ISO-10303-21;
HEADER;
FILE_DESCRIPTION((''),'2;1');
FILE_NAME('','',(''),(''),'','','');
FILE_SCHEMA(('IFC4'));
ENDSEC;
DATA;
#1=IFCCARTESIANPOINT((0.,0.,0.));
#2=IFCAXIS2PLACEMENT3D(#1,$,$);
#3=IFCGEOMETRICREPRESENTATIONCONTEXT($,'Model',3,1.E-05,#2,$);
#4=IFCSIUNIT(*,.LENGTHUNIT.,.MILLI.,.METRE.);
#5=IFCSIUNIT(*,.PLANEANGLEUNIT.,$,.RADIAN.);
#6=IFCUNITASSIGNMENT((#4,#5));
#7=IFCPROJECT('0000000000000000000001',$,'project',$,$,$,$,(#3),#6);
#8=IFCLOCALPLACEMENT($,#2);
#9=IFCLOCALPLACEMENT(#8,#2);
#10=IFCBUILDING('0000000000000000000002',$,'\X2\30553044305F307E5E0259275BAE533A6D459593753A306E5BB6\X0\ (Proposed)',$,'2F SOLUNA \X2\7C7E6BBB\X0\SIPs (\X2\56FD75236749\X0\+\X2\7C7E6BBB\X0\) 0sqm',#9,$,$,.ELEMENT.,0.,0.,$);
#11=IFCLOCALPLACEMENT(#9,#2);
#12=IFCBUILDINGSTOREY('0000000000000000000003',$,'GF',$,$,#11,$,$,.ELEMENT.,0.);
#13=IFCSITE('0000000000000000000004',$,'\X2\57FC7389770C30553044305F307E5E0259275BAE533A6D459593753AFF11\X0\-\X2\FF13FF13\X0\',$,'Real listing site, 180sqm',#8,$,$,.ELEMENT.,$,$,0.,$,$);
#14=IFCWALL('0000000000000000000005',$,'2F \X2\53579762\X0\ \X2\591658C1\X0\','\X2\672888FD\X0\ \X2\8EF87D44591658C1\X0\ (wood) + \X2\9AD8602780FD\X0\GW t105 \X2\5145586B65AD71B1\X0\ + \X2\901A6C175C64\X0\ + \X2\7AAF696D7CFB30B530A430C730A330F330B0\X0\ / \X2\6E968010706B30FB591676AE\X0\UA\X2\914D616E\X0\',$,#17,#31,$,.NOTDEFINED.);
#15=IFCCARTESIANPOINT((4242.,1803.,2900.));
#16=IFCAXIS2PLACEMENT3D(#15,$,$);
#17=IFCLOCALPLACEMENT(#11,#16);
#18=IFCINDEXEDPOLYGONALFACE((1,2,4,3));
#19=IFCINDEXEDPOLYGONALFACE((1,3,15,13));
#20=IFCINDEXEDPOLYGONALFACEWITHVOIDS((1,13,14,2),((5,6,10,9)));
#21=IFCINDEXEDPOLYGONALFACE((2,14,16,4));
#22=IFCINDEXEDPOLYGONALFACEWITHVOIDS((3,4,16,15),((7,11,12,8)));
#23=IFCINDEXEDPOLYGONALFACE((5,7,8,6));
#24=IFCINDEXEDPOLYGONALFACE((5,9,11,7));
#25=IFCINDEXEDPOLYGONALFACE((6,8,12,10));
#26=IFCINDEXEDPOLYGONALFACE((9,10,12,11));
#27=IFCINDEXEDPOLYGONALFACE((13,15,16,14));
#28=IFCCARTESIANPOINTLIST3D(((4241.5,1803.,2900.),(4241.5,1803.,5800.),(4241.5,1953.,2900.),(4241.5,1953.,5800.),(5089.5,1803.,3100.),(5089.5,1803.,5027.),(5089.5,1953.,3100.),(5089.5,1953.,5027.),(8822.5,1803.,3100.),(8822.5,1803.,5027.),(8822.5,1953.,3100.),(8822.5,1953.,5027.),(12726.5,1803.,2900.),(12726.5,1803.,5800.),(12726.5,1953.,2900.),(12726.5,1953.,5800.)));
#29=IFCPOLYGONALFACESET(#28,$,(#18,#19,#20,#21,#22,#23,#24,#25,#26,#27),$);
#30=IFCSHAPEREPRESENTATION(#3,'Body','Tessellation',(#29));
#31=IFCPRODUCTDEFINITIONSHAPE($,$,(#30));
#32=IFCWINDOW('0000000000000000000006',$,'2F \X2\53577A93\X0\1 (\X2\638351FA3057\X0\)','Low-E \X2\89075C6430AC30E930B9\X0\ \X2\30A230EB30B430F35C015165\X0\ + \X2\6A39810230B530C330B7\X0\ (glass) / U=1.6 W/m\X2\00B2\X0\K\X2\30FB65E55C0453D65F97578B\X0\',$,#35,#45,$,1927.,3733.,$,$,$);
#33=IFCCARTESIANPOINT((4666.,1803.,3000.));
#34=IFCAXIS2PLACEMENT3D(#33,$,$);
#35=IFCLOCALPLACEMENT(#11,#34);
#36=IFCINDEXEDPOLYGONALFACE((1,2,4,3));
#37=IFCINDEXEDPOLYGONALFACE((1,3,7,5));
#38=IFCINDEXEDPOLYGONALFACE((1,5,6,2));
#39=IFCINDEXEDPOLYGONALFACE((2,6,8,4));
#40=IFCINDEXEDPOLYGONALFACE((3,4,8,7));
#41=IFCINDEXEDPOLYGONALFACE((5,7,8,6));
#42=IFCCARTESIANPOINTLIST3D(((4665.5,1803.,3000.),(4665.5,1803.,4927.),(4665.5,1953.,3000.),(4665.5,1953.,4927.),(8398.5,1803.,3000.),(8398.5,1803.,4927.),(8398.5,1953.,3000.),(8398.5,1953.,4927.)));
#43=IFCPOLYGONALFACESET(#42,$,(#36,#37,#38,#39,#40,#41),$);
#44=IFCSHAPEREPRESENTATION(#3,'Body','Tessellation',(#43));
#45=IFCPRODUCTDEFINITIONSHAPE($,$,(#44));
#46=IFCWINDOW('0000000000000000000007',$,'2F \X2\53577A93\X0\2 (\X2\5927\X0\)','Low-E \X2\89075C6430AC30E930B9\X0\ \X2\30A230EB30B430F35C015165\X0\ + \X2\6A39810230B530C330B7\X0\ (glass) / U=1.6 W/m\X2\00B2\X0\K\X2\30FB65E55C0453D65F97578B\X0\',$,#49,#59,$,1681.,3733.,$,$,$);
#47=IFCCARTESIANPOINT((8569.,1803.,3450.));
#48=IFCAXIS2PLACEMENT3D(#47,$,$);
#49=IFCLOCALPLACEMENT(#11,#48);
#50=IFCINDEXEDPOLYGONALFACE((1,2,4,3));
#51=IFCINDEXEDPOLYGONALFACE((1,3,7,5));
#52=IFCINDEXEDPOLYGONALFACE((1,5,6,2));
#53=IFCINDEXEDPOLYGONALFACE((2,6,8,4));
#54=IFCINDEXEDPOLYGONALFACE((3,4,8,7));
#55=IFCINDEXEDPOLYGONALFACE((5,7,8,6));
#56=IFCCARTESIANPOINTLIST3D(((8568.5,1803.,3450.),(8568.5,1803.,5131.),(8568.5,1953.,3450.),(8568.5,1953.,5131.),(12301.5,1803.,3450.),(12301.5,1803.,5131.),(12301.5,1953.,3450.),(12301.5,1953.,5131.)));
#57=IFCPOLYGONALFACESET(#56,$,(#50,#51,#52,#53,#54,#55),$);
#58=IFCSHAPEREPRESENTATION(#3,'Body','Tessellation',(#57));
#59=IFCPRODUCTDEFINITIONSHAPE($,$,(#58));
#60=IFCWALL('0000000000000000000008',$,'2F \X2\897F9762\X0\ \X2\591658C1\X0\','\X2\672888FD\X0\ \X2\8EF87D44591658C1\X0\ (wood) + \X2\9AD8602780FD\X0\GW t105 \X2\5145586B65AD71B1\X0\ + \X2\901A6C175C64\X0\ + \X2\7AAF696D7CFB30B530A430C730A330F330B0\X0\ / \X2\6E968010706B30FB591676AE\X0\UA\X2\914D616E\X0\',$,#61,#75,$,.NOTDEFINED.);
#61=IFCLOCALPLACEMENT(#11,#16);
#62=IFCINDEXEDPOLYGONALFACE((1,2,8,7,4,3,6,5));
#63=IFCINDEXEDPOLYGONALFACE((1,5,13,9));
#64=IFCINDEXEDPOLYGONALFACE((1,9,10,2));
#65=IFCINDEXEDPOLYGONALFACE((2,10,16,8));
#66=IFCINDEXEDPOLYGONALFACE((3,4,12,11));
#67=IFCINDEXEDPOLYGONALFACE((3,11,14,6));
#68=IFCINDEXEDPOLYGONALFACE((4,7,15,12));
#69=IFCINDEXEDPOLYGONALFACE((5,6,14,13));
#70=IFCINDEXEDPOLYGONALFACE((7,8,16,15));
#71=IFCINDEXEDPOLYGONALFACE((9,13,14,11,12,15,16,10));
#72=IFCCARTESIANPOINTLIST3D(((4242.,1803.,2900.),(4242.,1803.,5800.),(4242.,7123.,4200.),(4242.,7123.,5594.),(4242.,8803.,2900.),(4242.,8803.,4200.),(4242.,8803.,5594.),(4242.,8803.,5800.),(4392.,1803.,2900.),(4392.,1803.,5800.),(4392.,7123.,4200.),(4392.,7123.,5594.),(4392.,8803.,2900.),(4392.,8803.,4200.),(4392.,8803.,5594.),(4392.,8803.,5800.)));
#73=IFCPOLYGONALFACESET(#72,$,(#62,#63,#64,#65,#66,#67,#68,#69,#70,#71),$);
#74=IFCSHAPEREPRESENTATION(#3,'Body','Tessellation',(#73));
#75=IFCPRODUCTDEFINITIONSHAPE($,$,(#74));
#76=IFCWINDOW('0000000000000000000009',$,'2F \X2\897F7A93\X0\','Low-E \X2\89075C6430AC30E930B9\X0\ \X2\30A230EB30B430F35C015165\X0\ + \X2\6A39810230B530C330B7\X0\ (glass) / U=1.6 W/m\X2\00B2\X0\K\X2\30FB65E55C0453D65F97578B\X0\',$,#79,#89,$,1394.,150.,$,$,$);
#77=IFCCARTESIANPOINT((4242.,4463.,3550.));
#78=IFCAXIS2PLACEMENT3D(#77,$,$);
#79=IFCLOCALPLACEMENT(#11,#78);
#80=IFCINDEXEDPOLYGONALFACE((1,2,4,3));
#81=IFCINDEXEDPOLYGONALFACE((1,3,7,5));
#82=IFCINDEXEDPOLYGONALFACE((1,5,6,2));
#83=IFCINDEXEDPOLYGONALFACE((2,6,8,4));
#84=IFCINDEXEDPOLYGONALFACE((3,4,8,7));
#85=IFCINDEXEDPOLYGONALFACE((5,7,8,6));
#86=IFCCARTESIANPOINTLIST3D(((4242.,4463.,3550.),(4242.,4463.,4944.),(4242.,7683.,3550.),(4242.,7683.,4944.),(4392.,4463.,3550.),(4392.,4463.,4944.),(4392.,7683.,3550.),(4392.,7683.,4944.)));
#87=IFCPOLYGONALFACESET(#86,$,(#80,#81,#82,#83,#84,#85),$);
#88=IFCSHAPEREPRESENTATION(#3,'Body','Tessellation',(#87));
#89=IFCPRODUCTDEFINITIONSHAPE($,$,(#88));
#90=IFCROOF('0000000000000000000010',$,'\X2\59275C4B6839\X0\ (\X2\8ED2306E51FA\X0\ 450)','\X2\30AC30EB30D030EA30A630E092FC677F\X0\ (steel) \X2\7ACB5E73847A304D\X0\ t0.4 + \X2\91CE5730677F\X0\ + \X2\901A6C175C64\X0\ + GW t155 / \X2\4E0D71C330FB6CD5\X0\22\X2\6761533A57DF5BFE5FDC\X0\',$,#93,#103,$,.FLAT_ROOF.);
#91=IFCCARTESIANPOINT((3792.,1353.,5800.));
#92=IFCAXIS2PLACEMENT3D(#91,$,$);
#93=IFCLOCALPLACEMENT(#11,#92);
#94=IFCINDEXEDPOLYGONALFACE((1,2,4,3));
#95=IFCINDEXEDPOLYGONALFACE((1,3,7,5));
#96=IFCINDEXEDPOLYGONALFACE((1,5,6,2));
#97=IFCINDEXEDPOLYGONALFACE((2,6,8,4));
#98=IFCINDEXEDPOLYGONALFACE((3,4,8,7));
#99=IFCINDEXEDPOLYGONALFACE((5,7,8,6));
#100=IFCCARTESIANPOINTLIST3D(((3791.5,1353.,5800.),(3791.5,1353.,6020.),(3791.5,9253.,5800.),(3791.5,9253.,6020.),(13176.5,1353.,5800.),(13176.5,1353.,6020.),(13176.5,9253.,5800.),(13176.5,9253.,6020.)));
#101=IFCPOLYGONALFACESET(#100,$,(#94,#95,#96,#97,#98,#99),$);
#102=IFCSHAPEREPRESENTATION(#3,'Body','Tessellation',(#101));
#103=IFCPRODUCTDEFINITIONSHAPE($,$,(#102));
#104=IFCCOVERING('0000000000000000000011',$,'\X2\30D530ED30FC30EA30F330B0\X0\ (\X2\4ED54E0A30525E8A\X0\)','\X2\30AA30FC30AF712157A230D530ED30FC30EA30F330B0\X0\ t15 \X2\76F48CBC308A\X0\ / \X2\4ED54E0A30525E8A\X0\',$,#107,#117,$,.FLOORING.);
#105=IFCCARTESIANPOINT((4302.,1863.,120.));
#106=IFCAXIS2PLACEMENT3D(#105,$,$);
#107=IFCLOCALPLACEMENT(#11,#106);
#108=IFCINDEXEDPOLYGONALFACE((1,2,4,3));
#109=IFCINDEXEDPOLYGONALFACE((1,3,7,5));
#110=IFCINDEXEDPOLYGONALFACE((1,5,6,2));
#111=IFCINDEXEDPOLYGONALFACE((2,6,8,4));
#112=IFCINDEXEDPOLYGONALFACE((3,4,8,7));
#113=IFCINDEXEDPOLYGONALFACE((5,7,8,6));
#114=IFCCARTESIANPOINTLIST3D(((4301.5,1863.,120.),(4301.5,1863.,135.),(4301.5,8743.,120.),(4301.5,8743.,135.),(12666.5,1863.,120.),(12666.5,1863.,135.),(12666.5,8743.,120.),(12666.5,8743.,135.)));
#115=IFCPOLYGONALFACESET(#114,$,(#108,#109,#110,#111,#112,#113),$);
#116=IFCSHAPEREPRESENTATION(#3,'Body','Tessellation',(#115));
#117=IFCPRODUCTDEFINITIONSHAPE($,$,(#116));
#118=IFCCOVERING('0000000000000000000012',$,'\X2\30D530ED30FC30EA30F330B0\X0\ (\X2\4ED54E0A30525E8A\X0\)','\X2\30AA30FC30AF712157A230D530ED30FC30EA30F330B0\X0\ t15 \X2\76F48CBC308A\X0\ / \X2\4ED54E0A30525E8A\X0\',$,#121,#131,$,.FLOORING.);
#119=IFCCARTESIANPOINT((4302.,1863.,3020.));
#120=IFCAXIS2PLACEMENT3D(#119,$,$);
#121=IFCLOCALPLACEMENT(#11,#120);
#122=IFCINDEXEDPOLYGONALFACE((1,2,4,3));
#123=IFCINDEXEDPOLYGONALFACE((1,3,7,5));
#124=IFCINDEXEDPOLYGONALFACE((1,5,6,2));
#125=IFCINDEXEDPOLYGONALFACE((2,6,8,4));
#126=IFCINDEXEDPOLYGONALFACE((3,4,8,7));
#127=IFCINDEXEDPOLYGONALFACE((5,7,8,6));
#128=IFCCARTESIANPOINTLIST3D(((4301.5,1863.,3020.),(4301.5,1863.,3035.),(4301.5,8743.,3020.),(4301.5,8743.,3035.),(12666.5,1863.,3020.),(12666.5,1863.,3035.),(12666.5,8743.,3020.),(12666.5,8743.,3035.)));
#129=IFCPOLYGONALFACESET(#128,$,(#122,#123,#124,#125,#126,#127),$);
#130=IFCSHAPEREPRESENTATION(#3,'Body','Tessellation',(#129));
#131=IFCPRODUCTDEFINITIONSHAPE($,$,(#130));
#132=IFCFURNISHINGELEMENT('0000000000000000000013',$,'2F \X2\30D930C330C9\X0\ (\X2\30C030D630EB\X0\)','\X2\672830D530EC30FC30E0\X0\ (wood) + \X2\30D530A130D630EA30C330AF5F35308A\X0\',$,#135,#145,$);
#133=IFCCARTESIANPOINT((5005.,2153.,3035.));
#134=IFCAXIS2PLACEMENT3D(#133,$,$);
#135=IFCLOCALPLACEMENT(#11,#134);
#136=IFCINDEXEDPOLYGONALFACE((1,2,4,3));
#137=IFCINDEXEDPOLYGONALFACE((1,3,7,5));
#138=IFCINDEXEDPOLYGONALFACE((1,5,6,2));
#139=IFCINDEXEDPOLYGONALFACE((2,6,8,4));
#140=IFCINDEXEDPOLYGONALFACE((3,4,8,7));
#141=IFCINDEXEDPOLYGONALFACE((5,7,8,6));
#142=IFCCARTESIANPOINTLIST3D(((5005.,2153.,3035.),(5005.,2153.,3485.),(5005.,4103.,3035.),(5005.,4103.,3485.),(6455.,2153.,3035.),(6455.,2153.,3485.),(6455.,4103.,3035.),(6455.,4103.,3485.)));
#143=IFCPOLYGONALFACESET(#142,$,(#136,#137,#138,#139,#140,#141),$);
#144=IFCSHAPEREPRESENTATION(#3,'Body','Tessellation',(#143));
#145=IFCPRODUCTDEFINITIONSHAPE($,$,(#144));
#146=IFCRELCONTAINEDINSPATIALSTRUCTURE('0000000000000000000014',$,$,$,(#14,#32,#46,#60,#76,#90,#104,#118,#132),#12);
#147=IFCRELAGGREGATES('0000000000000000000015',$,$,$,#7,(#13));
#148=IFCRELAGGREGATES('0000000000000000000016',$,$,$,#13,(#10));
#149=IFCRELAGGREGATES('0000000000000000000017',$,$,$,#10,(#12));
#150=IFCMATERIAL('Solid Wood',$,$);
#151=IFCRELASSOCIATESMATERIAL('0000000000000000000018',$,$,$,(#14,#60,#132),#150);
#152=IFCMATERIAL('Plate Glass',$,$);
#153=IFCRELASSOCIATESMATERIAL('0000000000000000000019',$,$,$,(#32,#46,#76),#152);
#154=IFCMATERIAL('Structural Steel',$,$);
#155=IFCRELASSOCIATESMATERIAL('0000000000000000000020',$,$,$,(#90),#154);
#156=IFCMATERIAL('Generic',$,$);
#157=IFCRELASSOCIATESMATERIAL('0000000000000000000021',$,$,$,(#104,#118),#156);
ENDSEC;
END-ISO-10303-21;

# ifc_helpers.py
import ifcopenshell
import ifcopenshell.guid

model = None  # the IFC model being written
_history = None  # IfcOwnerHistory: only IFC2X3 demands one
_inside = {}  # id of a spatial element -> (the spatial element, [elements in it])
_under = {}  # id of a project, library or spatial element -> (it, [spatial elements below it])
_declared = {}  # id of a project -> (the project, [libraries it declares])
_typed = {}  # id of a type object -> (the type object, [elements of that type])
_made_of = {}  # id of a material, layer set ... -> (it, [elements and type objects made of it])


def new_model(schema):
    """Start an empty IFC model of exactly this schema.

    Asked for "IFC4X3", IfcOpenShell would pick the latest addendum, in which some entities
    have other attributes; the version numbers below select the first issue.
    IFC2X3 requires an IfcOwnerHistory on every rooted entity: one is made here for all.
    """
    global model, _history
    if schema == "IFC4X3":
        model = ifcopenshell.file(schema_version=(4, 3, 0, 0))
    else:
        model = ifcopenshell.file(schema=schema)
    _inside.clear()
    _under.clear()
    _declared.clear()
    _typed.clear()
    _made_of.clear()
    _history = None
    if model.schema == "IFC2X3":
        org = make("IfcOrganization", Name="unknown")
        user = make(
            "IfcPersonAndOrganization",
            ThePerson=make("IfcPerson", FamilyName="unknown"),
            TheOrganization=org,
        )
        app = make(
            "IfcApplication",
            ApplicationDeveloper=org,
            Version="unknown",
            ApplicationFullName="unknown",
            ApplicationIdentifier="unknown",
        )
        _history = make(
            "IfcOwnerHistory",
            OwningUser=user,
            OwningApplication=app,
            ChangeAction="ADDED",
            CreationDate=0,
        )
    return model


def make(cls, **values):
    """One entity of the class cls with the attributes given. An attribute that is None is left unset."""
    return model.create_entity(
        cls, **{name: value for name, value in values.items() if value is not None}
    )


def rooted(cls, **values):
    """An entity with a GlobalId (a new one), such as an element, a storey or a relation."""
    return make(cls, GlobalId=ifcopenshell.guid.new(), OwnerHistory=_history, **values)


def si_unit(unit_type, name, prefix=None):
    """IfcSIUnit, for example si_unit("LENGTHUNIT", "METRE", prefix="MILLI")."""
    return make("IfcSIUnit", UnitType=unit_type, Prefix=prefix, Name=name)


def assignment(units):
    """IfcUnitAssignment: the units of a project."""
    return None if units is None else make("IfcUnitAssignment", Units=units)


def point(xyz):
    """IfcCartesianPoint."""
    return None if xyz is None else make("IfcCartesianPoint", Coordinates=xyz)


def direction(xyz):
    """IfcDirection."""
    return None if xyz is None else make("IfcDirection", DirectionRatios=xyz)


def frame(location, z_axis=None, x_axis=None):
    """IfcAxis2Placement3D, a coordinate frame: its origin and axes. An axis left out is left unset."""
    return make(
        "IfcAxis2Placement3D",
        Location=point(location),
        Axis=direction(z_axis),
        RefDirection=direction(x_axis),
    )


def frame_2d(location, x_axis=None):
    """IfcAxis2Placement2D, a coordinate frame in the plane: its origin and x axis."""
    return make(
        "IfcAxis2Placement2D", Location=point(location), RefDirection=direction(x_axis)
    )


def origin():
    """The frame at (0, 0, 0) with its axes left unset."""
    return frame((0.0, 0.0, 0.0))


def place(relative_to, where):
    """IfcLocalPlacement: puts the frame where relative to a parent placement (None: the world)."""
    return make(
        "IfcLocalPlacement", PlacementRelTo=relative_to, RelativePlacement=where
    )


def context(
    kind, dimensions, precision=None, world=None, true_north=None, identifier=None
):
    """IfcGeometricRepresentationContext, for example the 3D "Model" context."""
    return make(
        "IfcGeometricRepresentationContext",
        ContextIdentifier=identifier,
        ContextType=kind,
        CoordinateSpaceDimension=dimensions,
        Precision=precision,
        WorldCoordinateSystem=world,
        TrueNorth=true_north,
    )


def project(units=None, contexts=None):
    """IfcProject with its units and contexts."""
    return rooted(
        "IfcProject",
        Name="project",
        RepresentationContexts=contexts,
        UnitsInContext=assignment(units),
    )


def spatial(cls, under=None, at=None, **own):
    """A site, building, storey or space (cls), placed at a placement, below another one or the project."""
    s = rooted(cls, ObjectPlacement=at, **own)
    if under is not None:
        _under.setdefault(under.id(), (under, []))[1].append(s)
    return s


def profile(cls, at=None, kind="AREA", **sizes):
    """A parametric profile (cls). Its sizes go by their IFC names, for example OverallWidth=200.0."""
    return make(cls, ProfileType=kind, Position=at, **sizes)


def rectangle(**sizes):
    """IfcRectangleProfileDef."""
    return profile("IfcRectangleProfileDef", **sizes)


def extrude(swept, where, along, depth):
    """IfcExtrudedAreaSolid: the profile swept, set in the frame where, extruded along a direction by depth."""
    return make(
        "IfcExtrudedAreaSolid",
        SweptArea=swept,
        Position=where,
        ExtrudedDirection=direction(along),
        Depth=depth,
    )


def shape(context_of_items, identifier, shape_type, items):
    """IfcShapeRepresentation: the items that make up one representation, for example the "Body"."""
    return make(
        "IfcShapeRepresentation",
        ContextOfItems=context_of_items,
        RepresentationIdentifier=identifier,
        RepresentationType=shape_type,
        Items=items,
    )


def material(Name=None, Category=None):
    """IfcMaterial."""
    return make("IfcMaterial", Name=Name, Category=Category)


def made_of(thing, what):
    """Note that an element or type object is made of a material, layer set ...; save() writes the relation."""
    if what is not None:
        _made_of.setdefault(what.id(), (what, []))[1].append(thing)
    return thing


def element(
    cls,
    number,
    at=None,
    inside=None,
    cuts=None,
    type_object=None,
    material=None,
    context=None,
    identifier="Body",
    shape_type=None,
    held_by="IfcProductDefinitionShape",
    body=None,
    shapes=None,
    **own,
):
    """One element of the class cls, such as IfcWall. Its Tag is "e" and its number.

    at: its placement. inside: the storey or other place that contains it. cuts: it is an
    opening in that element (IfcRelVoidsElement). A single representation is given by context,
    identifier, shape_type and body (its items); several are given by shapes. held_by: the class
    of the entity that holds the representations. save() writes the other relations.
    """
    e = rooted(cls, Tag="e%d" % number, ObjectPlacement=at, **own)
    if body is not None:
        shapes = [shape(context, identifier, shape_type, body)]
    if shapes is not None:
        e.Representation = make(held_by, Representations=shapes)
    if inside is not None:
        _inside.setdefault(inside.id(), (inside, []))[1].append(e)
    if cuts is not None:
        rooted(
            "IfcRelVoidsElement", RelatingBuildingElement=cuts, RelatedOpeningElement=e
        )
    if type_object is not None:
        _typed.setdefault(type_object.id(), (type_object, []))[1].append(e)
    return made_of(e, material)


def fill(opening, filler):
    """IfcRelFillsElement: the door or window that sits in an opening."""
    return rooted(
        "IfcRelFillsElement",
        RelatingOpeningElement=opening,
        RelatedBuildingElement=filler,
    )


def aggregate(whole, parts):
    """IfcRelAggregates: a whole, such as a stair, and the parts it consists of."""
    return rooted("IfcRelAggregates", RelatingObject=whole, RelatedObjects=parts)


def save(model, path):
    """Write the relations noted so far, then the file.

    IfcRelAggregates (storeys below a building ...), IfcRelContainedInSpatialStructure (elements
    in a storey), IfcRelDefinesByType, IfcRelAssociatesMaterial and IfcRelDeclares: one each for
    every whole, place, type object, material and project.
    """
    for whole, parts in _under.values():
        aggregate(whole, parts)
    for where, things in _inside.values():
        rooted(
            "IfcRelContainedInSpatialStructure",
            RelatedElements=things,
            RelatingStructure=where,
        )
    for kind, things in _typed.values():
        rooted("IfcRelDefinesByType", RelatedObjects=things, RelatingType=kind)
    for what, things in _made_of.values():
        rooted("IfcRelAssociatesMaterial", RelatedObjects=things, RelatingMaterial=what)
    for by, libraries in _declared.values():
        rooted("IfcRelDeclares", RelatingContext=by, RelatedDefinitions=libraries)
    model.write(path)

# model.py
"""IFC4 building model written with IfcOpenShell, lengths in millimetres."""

from ifc_helpers import new_model, si_unit, frame, frame_2d, origin, place, context, project, spatial, rectangle, extrude, material, element, fill, save


model = new_model("IFC4")

# Units and contexts
model_context = context("Model", 3, precision=1e-05, world=origin())
ifc_project = project(units=[si_unit("LENGTHUNIT", "METRE", prefix="MILLI"), si_unit("PLANEANGLEUNIT", "RADIAN")], contexts=[model_context])

# Site, building, storey
site_placement = place(None, origin())
site = spatial("IfcSite", under=ifc_project, at=site_placement, Name="埼玉県さいたま市大宮区浅間町１-３３", ObjectType="Real listing site, 180sqm", CompositionType="ELEMENT", RefElevation=0.0)
building_placement = place(site_placement, origin())
building = spatial("IfcBuilding", under=site, at=building_placement, Name="さいたま市大宮区浅間町の家 (Proposed)", ObjectType="2F SOLUNA 籾殻SIPs (国産杉+籾殻) 0sqm", CompositionType="ELEMENT", ElevationOfRefHeight=0.0, ElevationOfTerrain=0.0)
storey_placement = place(building_placement, origin())
storey = spatial("IfcBuildingStorey", under=building, at=storey_placement, Name="GF", CompositionType="ELEMENT", Elevation=0.0)

# Shared definitions
ifc_material_1 = material(Name="Solid Wood")

# Shared definitions
ifc_material_2 = material(Name="Plate Glass")

# Wall, openings, windows
wall_1_placement = place(storey_placement, frame((4242.0, 1803.0, 2900.0)))
wall_1 = element("IfcWall", 1, at=wall_1_placement, inside=storey, material=ifc_material_1, Name="2F 南面 外壁", Description="木製 軸組外壁 (wood) + 高性能GW t105 充填断熱 + 通気層 + 窯業系サイディング / 準耐火・外皮UA配慮", PredefinedType="NOTDEFINED", context=model_context, shape_type="SweptSolid", body=[
    extrude(rectangle(XDim=8485.0, YDim=150.0, at=frame_2d((4242.0, 75.0))), frame((4242.0, 1803.0, 2900.0)), (0.0, 0.0, 1.0), 2900.0),
])
opening_1_placement = place(storey_placement, frame((4666.0, 1803.0, 3000.0)))
opening_1 = element("IfcOpeningElement", 2, at=opening_1_placement, cuts=wall_1, PredefinedType="NOTDEFINED", context=model_context, shape_type="SweptSolid", body=[
    extrude(rectangle(XDim=3733.0, YDim=150.0, at=frame_2d((1866.0, 75.0))), frame((4666.0, 1803.0, 3000.0)), (0.0, 0.0, 1.0), 1927.0),
])
opening_2_placement = place(storey_placement, frame((8569.0, 1803.0, 3450.0)))
opening_2 = element("IfcOpeningElement", 3, at=opening_2_placement, cuts=wall_1, PredefinedType="NOTDEFINED", context=model_context, shape_type="SweptSolid", body=[
    extrude(rectangle(XDim=3733.0, YDim=150.0, at=frame_2d((1866.0, 75.0))), frame((8569.0, 1803.0, 3450.0)), (0.0, 0.0, 1.0), 1681.0),
])
window_1_placement = place(storey_placement, frame((4666.0, 1803.0, 3000.0)))
window_1 = element("IfcWindow", 4, at=window_1_placement, inside=storey, material=ifc_material_2, Name="2F 南窓1 (掃出し)", Description="Low-E 複層ガラス アルゴン封入 + 樹脂サッシ (glass) / U=1.6 W/m²K・日射取得型", OverallHeight=1927.0, OverallWidth=3733.0, context=model_context, shape_type="SweptSolid", body=[
    extrude(rectangle(XDim=3733.0, YDim=150.0, at=frame_2d((1866.0, 75.0))), frame((4666.0, 1803.0, 3000.0)), (0.0, 0.0, 1.0), 1927.0),
])
fill(opening_1, window_1)
window_2_placement = place(storey_placement, frame((8569.0, 1803.0, 3450.0)))
window_2 = element("IfcWindow", 5, at=window_2_placement, inside=storey, material=ifc_material_2, Name="2F 南窓2 (大)", Description="Low-E 複層ガラス アルゴン封入 + 樹脂サッシ (glass) / U=1.6 W/m²K・日射取得型", OverallHeight=1681.0, OverallWidth=3733.0, context=model_context, shape_type="SweptSolid", body=[
    extrude(rectangle(XDim=3733.0, YDim=150.0, at=frame_2d((1866.0, 75.0))), frame((8569.0, 1803.0, 3450.0)), (0.0, 0.0, 1.0), 1681.0),
])
fill(opening_2, window_2)

# Wall, opening, window
wall_2_placement = place(storey_placement, frame((4242.0, 1803.0, 2900.0)))
wall_2 = element("IfcWall", 6, at=wall_2_placement, inside=storey, material=ifc_material_1, Name="2F 西面 外壁", Description="木製 軸組外壁 (wood) + 高性能GW t105 充填断熱 + 通気層 + 窯業系サイディング / 準耐火・外皮UA配慮", PredefinedType="NOTDEFINED", context=model_context, shape_type="SweptSolid", body=[
    extrude(rectangle(XDim=150.0, YDim=7000.0, at=frame_2d((75.0, 3500.0))), frame((4242.0, 1803.0, 2900.0)), (0.0, 0.0, 1.0), 2900.0),
])
opening_3_placement = place(storey_placement, frame((4242.0, 4463.0, 3550.0)))
opening_3 = element("IfcOpeningElement", 7, at=opening_3_placement, cuts=wall_2, PredefinedType="NOTDEFINED", context=model_context, shape_type="SweptSolid", body=[
    extrude(rectangle(XDim=150.0, YDim=3220.0, at=frame_2d((75.0, 1610.0))), frame((4242.0, 4463.0, 3550.0)), (0.0, 0.0, 1.0), 1394.0),
])
window_3_placement = place(storey_placement, frame((4242.0, 4463.0, 3550.0)))
window_3 = element("IfcWindow", 8, at=window_3_placement, inside=storey, material=ifc_material_2, Name="2F 西窓", Description="Low-E 複層ガラス アルゴン封入 + 樹脂サッシ (glass) / U=1.6 W/m²K・日射取得型", OverallHeight=1394.0, OverallWidth=150.0, context=model_context, shape_type="SweptSolid", body=[
    extrude(rectangle(XDim=150.0, YDim=3220.0, at=frame_2d((75.0, 1610.0))), frame((4242.0, 4463.0, 3550.0)), (0.0, 0.0, 1.0), 1394.0),
])
fill(opening_3, window_3)

# Roof
ifc_material_3 = material(Name="Structural Steel")
roof_placement = place(storey_placement, frame((3792.0, 1353.0, 5800.0)))
element("IfcRoof", 9, at=roof_placement, inside=storey, material=ifc_material_3, Name="大屋根 (軒の出 450)", Description="ガルバリウム鋼板 (steel) 立平葺き t0.4 + 野地板 + 通気層 + GW t155 / 不燃・法22条区域対応", PredefinedType="FLAT_ROOF", context=model_context, shape_type="SweptSolid", body=[
    extrude(rectangle(XDim=9385.0, YDim=7900.0, at=frame_2d((4692.0, 3950.0))), frame((3792.0, 1353.0, 5800.0)), (0.0, 0.0, 1.0), 220.0),
])

# Coverings
ifc_material_4 = material(Name="Generic")
covering_1_placement = place(storey_placement, frame((4302.0, 1863.0, 120.0)))
element("IfcCovering", 10, at=covering_1_placement, inside=storey, material=ifc_material_4, Name="フローリング (仕上げ床)", Description="オーク無垢フローリング t15 直貼り / 仕上げ床", PredefinedType="FLOORING", context=model_context, shape_type="SweptSolid", body=[
    extrude(rectangle(XDim=8365.0, YDim=6880.0, at=frame_2d((4182.0, 3440.0))), frame((4302.0, 1863.0, 120.0)), (0.0, 0.0, 1.0), 15.0),
])
covering_2_placement = place(storey_placement, frame((4302.0, 1863.0, 3020.0)))
element("IfcCovering", 11, at=covering_2_placement, inside=storey, material=ifc_material_4, Name="フローリング (仕上げ床)", Description="オーク無垢フローリング t15 直貼り / 仕上げ床", PredefinedType="FLOORING", context=model_context, shape_type="SweptSolid", body=[
    extrude(rectangle(XDim=8365.0, YDim=6880.0, at=frame_2d((4182.0, 3440.0))), frame((4302.0, 1863.0, 3020.0)), (0.0, 0.0, 1.0), 15.0),
])

# Furnishing element
furnishing_placement = place(storey_placement, frame((5005.0, 2153.0, 3035.0)))
element("IfcFurnishingElement", 12, at=furnishing_placement, inside=storey, material=ifc_material_1, Name="2F ベッド (ダブル)", Description="木フレーム (wood) + ファブリック張り", context=model_context, shape_type="SweptSolid", body=[
    extrude(rectangle(XDim=1450.0, YDim=1950.0, at=frame_2d((725.0, 975.0))), frame((5005.0, 2153.0, 3035.0)), (0.0, 0.0, 1.0), 450.0),
])

save(model, "model.ifc")
